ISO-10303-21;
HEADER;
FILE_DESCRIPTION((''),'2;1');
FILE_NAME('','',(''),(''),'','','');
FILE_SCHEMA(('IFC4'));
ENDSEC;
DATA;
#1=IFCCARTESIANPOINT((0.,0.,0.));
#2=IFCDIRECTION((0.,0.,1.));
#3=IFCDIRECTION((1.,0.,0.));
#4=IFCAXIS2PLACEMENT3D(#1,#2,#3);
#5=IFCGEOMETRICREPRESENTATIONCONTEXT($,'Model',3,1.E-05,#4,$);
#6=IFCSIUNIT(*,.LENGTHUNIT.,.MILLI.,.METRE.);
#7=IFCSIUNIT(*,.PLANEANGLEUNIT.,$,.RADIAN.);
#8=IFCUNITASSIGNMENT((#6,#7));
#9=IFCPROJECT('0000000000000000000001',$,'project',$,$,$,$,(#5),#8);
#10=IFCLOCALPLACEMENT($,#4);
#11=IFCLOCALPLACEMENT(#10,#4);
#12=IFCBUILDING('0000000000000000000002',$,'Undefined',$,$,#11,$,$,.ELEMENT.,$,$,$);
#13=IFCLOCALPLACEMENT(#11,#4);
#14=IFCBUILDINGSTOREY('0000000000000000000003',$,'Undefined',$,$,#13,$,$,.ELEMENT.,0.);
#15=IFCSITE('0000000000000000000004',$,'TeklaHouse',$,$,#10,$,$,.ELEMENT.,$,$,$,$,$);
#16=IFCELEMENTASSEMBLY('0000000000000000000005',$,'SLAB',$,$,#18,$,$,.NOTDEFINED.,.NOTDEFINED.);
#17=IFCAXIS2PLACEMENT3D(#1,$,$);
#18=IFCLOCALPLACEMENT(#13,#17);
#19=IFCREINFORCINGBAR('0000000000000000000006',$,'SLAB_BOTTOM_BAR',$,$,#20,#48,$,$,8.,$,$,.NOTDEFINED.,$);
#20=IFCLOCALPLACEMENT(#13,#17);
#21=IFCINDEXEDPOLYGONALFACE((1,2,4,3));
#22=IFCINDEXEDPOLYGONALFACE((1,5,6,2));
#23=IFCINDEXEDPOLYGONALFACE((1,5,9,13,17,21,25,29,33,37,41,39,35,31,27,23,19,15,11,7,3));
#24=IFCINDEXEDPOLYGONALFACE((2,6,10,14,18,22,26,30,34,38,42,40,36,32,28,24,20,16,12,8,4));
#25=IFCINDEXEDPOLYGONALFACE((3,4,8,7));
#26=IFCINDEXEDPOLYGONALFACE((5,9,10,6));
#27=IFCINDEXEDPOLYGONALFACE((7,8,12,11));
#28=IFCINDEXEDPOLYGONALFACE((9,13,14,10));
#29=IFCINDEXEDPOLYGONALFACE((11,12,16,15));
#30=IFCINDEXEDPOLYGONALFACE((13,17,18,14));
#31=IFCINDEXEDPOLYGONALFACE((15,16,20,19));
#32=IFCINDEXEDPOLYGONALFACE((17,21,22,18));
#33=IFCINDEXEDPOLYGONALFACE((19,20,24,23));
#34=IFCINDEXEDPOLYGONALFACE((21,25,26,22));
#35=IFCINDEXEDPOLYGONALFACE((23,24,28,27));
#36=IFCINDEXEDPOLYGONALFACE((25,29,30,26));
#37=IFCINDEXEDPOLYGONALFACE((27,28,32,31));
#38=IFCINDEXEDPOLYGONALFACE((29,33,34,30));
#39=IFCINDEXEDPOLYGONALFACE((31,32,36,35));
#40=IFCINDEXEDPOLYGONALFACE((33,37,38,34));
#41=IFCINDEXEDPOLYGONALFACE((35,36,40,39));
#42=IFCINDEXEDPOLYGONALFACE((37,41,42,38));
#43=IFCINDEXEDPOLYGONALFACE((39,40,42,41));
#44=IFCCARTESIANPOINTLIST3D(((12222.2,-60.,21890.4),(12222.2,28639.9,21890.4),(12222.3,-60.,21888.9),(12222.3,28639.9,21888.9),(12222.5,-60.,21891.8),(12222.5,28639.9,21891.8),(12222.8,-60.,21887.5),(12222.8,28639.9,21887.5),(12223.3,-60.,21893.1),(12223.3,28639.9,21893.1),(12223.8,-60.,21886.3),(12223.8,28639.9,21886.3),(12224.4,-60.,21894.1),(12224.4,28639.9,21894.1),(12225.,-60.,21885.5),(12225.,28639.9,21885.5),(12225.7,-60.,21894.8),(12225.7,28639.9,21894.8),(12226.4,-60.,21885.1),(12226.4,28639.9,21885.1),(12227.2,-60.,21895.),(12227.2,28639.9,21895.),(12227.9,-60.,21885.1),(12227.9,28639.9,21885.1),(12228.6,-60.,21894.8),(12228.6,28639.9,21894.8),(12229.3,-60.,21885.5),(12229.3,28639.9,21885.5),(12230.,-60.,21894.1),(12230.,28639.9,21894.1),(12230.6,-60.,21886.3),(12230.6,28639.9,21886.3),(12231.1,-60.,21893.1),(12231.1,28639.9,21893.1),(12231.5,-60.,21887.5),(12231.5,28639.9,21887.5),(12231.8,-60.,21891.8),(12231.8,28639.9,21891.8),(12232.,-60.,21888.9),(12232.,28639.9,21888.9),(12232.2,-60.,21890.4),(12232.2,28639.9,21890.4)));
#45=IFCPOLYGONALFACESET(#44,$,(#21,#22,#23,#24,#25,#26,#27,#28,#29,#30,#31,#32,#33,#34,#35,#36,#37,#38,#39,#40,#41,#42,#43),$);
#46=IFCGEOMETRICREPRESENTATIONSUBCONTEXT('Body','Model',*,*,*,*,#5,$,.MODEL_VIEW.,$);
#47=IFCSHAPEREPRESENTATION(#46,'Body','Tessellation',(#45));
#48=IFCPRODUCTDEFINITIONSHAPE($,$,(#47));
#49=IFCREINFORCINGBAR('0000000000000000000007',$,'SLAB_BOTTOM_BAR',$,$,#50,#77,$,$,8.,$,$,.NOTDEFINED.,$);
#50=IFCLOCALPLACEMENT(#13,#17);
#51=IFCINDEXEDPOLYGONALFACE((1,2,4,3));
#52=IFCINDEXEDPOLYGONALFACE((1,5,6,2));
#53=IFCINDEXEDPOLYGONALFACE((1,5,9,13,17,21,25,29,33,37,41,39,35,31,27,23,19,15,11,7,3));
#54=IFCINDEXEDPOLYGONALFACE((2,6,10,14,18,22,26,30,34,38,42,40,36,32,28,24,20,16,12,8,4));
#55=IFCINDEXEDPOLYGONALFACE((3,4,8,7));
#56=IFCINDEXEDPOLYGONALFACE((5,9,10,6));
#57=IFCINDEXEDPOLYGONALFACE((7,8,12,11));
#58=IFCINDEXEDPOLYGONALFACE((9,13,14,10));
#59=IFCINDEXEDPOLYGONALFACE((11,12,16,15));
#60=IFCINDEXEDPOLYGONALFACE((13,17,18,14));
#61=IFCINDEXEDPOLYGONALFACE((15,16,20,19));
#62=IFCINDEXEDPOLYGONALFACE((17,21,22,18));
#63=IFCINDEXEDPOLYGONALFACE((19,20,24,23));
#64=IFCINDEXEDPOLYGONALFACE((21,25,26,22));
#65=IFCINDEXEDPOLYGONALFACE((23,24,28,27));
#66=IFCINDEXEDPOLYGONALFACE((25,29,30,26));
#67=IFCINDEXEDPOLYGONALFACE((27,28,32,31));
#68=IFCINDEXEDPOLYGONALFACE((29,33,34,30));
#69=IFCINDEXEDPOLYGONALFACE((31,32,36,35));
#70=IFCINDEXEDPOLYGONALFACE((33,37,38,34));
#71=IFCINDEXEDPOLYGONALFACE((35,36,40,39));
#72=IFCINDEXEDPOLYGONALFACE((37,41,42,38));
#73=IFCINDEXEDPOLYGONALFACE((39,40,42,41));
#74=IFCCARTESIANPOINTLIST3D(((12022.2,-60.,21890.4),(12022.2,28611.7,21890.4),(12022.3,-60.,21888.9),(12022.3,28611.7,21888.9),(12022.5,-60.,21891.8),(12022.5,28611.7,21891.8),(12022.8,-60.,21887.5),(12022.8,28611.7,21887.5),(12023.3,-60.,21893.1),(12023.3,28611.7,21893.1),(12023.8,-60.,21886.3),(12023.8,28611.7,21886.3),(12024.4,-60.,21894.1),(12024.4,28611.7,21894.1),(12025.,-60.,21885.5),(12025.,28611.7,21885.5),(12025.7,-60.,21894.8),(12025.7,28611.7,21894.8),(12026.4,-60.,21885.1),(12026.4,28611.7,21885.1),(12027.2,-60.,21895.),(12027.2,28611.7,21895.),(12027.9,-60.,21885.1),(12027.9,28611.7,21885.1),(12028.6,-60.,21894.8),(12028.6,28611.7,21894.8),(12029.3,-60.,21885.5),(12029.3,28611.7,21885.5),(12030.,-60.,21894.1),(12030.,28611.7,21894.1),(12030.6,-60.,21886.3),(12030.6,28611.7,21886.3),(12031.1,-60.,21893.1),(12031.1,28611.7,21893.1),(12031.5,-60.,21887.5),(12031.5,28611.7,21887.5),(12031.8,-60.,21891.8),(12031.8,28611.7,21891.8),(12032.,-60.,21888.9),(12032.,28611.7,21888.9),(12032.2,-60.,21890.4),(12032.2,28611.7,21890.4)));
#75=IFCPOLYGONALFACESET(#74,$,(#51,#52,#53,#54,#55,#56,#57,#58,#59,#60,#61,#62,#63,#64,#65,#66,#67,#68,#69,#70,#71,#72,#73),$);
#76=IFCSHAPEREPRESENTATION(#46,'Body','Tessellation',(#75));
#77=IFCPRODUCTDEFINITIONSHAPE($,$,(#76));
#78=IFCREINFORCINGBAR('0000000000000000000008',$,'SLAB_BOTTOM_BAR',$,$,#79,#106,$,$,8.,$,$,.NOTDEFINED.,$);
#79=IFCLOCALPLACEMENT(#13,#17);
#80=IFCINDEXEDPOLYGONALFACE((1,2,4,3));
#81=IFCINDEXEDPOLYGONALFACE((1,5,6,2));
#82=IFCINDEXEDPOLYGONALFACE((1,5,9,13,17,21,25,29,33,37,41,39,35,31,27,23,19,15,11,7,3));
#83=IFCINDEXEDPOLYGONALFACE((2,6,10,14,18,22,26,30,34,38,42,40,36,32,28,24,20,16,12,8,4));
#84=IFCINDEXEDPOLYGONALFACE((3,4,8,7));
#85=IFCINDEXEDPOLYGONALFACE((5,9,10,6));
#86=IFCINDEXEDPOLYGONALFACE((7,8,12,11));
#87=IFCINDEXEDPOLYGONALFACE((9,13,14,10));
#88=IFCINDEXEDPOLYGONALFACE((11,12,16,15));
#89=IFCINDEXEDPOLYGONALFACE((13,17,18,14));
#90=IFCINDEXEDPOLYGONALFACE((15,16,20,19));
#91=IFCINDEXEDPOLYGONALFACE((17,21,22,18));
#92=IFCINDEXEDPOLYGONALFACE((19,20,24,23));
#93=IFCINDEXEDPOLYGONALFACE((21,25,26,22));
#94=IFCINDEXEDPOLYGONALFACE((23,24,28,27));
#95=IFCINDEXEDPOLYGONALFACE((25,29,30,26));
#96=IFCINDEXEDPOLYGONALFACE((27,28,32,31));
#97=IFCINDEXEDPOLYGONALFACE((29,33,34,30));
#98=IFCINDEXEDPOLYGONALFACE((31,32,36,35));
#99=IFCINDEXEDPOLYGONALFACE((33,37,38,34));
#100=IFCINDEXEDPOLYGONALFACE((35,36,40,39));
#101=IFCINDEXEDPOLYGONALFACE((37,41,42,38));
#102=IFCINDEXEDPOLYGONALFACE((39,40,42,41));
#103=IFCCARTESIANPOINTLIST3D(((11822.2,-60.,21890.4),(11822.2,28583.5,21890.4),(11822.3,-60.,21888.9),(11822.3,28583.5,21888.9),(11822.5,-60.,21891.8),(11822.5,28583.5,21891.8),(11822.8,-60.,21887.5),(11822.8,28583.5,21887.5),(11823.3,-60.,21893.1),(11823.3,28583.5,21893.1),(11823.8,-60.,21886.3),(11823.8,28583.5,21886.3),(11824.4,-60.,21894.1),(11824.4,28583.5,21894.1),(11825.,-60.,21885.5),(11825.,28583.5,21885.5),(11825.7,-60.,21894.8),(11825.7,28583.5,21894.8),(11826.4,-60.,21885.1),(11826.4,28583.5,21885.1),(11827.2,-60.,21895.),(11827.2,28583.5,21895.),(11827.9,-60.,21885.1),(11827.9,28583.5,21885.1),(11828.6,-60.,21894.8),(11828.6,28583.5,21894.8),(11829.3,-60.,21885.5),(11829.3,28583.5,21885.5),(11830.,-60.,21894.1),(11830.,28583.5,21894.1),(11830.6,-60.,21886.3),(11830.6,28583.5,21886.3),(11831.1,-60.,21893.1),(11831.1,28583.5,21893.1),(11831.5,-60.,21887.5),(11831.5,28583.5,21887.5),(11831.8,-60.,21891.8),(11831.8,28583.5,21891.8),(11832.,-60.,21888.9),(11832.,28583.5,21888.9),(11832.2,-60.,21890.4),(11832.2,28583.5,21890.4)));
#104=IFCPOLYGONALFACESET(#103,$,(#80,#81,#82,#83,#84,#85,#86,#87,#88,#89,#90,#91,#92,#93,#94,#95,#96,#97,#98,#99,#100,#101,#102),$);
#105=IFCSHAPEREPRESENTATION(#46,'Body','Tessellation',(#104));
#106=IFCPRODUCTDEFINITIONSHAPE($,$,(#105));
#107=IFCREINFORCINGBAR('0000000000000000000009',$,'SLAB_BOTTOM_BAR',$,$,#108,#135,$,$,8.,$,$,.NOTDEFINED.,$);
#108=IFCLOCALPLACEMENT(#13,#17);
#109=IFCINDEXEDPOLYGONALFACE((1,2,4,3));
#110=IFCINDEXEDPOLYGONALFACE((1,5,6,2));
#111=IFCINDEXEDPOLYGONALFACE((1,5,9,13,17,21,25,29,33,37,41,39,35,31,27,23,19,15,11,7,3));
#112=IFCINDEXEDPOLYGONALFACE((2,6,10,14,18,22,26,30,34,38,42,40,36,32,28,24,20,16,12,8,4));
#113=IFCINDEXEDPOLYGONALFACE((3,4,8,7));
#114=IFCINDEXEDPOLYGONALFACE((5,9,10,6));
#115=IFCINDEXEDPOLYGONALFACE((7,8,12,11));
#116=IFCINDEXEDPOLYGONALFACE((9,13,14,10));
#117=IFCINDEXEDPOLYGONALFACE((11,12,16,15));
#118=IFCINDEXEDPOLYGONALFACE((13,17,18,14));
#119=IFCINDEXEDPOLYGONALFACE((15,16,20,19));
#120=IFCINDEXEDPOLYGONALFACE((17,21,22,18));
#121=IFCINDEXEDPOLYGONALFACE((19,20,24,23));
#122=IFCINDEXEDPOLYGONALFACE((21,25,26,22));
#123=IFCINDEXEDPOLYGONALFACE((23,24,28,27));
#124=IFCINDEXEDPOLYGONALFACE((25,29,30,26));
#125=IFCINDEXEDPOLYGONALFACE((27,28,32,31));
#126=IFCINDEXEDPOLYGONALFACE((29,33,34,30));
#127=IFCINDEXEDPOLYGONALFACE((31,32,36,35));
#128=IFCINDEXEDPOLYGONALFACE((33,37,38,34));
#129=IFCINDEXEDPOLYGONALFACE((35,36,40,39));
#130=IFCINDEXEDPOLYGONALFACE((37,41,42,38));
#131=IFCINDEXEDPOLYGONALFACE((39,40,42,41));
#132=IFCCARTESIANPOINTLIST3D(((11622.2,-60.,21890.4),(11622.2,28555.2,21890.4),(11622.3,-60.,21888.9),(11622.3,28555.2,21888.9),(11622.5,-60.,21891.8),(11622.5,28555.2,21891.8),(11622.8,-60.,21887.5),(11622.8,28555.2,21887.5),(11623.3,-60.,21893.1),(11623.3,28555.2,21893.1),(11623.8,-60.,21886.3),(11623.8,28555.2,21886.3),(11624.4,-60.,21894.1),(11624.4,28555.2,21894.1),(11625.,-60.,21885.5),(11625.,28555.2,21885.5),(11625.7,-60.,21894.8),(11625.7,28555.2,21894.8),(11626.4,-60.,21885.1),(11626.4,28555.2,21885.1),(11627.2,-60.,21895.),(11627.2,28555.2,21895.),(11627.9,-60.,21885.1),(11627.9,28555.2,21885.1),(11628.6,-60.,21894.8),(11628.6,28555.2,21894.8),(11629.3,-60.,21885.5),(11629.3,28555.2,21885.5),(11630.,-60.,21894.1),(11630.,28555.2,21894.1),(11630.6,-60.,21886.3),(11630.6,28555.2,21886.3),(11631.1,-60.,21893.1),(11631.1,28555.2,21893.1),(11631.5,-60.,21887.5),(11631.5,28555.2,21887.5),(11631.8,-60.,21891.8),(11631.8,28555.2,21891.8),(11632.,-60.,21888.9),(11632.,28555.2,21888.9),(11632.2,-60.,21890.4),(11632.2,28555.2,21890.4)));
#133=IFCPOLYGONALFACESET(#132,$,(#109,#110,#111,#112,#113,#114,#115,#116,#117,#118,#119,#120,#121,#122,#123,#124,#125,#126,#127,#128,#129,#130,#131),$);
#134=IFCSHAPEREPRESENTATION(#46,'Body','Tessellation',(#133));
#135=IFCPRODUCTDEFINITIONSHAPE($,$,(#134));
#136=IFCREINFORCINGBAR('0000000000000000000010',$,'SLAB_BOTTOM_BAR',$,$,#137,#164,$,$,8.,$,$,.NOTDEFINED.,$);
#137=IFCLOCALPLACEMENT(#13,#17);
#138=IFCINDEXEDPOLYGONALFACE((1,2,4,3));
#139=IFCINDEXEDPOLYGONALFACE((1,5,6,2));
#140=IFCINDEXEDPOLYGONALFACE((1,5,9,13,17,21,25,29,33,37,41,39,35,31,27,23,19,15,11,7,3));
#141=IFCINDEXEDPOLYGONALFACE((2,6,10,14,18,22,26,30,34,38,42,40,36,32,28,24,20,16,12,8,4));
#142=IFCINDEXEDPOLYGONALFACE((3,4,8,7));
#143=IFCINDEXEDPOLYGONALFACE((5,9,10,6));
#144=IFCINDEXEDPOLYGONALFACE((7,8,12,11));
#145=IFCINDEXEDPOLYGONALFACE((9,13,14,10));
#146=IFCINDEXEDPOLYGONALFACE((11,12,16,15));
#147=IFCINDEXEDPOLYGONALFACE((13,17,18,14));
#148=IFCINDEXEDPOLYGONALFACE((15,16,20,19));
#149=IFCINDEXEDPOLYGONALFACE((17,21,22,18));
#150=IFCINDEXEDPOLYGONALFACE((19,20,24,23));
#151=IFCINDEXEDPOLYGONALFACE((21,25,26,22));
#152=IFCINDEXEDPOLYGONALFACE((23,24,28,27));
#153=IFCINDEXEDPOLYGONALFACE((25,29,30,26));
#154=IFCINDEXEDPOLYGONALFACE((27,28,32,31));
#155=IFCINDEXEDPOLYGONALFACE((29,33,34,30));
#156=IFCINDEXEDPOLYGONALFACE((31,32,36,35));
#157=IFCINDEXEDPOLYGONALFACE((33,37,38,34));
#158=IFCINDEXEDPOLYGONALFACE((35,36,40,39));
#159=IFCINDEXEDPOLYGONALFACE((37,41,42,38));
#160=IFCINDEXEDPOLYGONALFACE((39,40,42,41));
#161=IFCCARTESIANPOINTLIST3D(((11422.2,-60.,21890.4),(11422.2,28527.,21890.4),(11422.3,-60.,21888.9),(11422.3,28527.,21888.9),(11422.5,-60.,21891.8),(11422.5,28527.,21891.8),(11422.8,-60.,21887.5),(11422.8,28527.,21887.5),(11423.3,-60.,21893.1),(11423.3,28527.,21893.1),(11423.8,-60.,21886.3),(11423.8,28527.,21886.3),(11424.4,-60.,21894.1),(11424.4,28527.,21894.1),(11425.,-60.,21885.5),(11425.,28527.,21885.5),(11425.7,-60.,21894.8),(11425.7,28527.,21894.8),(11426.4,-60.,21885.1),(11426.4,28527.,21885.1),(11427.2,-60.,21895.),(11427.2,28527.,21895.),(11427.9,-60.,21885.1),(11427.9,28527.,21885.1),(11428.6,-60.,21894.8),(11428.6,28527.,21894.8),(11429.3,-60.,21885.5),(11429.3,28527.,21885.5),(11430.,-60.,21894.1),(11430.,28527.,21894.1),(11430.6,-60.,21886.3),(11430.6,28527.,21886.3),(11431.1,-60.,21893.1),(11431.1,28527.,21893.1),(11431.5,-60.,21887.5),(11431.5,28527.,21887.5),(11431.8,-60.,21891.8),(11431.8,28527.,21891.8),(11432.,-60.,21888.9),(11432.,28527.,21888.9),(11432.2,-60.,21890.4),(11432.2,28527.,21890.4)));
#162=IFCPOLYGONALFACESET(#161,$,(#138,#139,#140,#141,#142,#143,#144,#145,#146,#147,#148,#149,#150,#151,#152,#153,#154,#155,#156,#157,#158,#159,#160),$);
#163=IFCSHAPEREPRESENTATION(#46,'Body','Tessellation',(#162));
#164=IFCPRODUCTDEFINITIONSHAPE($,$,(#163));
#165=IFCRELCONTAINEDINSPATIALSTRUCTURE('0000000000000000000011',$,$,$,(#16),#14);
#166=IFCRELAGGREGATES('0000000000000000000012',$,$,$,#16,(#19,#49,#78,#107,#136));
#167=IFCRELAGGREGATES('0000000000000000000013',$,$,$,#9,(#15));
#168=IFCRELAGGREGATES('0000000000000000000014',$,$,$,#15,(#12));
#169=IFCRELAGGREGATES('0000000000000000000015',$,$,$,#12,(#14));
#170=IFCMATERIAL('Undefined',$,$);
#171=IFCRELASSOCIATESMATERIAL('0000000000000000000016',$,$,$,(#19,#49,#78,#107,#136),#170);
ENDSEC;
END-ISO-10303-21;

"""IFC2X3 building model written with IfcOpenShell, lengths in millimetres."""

from ifc_helpers import new_model, entity, si_unit, frame, origin_with_axes, place, context, subcontext, project, spatial, source, transform, mapped, material, element, aggregate, save


model = new_model("IFC2X3")

# Units and contexts
model_context = context("Model", 3, precision=1e-05, world=origin_with_axes())
body_context = subcontext(model_context, "Body", "Model", "MODEL_VIEW")
ifc_project = project(units=[si_unit("LENGTHUNIT", "METRE", prefix="MILLI"), si_unit("PLANEANGLEUNIT", "RADIAN")], contexts=[model_context])

# Site, building, storey
site_placement = place(None, origin_with_axes())
site = spatial("IfcSite", under=ifc_project, at=site_placement, Name="TeklaHouse", CompositionType="ELEMENT")
building_placement = place(site_placement, origin_with_axes())
building = spatial("IfcBuilding", under=site, at=building_placement, Name="Undefined", CompositionType="ELEMENT")
storey_placement = place(building_placement, origin_with_axes())
storey = spatial("IfcBuildingStorey", under=building, at=storey_placement, Name="Undefined", CompositionType="ELEMENT", Elevation=0.0)

# Shared definitions
ifc_material_1 = material(Name="Undefined")

# Element assembly, reinforcing bars
assembly_1_placement = place(storey_placement, origin_with_axes())
assembly_1 = element("IfcElementAssembly", 1, at=assembly_1_placement, inside=storey, Name="SLAB", AssemblyPlace="NOTDEFINED", PredefinedType="NOTDEFINED")
shared_shape_1 = source(origin_with_axes(), body_context, "Body", "AdvancedSweptSolid", [
    entity("IfcSweptDiskSolid", entity("IfcTrimmedCurve", entity("IfcLine", entity("IfcCartesianPoint", [0.0, 0.0, 0.0]), entity("IfcVector", entity("IfcDirection", [1.0, 0.0, 0.0]), 1.0)), [entity("IfcParameterValue", 0.0)], [entity("IfcParameterValue", 28699.942252)], True, "PARAMETER"), 5.0, None, 0.0, 28699.9),
])
reinforcing_bar_1_placement = place(assembly_1_placement, frame((12227.2, -60.0, 21890.0), z_axis=(0.0, 0.0, 1.0), x_axis=(0.0, 1.0, 0.0)))
reinforcing_bar_1 = element("IfcReinforcingBar", 2, at=reinforcing_bar_1_placement, material=ifc_material_1, Name="SLAB_BOTTOM_BAR", BarRole="NOTDEFINED", NominalDiameter=8.0, context=body_context, shape_type="MappedRepresentation", body=[
    mapped(shared_shape_1, transform((0.0, 0.0, 0.0))),
])
shared_shape_2 = source(origin_with_axes(), body_context, "Body", "AdvancedSweptSolid", [
    entity("IfcSweptDiskSolid", entity("IfcTrimmedCurve", entity("IfcLine", entity("IfcCartesianPoint", [0.0, 0.0, 0.0]), entity("IfcVector", entity("IfcDirection", [1.0, 0.0, 0.0]), 1.0)), [entity("IfcParameterValue", 0.0)], [entity("IfcParameterValue", 28671.700141)], True, "PARAMETER"), 5.0, None, 0.0, 28671.7),
])
reinforcing_bar_2_placement = place(assembly_1_placement, frame((12027.2, -60.0, 21890.0), z_axis=(0.0, 0.0, 1.0), x_axis=(0.0, 1.0, 0.0)))
reinforcing_bar_2 = element("IfcReinforcingBar", 3, at=reinforcing_bar_2_placement, material=ifc_material_1, Name="SLAB_BOTTOM_BAR", BarRole="NOTDEFINED", NominalDiameter=8.0, context=body_context, shape_type="MappedRepresentation", body=[
    mapped(shared_shape_2, transform((0.0, 0.0, 0.0))),
])
shared_shape_3 = source(origin_with_axes(), body_context, "Body", "AdvancedSweptSolid", [
    entity("IfcSweptDiskSolid", entity("IfcTrimmedCurve", entity("IfcLine", entity("IfcCartesianPoint", [0.0, 0.0, 0.0]), entity("IfcVector", entity("IfcDirection", [1.0, 0.0, 0.0]), 1.0)), [entity("IfcParameterValue", 0.0)], [entity("IfcParameterValue", 28643.458031)], True, "PARAMETER"), 5.0, None, 0.0, 28643.5),
])
reinforcing_bar_3_placement = place(assembly_1_placement, frame((11827.2, -60.0, 21890.0), z_axis=(0.0, 0.0, 1.0), x_axis=(0.0, 1.0, 0.0)))
reinforcing_bar_3 = element("IfcReinforcingBar", 4, at=reinforcing_bar_3_placement, material=ifc_material_1, Name="SLAB_BOTTOM_BAR", BarRole="NOTDEFINED", NominalDiameter=8.0, context=body_context, shape_type="MappedRepresentation", body=[
    mapped(shared_shape_3, transform((0.0, 0.0, 0.0))),
])
shared_shape_4 = source(origin_with_axes(), body_context, "Body", "AdvancedSweptSolid", [
    entity("IfcSweptDiskSolid", entity("IfcTrimmedCurve", entity("IfcLine", entity("IfcCartesianPoint", [0.0, 0.0, 0.0]), entity("IfcVector", entity("IfcDirection", [1.0, 0.0, 0.0]), 1.0)), [entity("IfcParameterValue", 0.0)], [entity("IfcParameterValue", 28615.21592)], True, "PARAMETER"), 5.0, None, 0.0, 28615.2),
])
reinforcing_bar_4_placement = place(assembly_1_placement, frame((11627.2, -60.0, 21890.0), z_axis=(0.0, 0.0, 1.0), x_axis=(0.0, 1.0, 0.0)))
reinforcing_bar_4 = element("IfcReinforcingBar", 5, at=reinforcing_bar_4_placement, material=ifc_material_1, Name="SLAB_BOTTOM_BAR", BarRole="NOTDEFINED", NominalDiameter=8.0, context=body_context, shape_type="MappedRepresentation", body=[
    mapped(shared_shape_4, transform((0.0, 0.0, 0.0))),
])
shared_shape_5 = source(origin_with_axes(), body_context, "Body", "AdvancedSweptSolid", [
    entity("IfcSweptDiskSolid", entity("IfcTrimmedCurve", entity("IfcLine", entity("IfcCartesianPoint", [0.0, 0.0, 0.0]), entity("IfcVector", entity("IfcDirection", [1.0, 0.0, 0.0]), 1.0)), [entity("IfcParameterValue", 0.0)], [entity("IfcParameterValue", 28586.973809)], True, "PARAMETER"), 5.0, None, 0.0, 28587.0),
])
reinforcing_bar_5_placement = place(assembly_1_placement, frame((11427.2, -60.0, 21890.0), z_axis=(0.0, 0.0, 1.0), x_axis=(0.0, 1.0, 0.0)))
reinforcing_bar_5 = element("IfcReinforcingBar", 6, at=reinforcing_bar_5_placement, material=ifc_material_1, Name="SLAB_BOTTOM_BAR", BarRole="NOTDEFINED", NominalDiameter=8.0, context=body_context, shape_type="MappedRepresentation", body=[
    mapped(shared_shape_5, transform((0.0, 0.0, 0.0))),
])
aggregate(assembly_1, [reinforcing_bar_1, reinforcing_bar_2, reinforcing_bar_3, reinforcing_bar_4, reinforcing_bar_5])

save(model, "model.ifc")
